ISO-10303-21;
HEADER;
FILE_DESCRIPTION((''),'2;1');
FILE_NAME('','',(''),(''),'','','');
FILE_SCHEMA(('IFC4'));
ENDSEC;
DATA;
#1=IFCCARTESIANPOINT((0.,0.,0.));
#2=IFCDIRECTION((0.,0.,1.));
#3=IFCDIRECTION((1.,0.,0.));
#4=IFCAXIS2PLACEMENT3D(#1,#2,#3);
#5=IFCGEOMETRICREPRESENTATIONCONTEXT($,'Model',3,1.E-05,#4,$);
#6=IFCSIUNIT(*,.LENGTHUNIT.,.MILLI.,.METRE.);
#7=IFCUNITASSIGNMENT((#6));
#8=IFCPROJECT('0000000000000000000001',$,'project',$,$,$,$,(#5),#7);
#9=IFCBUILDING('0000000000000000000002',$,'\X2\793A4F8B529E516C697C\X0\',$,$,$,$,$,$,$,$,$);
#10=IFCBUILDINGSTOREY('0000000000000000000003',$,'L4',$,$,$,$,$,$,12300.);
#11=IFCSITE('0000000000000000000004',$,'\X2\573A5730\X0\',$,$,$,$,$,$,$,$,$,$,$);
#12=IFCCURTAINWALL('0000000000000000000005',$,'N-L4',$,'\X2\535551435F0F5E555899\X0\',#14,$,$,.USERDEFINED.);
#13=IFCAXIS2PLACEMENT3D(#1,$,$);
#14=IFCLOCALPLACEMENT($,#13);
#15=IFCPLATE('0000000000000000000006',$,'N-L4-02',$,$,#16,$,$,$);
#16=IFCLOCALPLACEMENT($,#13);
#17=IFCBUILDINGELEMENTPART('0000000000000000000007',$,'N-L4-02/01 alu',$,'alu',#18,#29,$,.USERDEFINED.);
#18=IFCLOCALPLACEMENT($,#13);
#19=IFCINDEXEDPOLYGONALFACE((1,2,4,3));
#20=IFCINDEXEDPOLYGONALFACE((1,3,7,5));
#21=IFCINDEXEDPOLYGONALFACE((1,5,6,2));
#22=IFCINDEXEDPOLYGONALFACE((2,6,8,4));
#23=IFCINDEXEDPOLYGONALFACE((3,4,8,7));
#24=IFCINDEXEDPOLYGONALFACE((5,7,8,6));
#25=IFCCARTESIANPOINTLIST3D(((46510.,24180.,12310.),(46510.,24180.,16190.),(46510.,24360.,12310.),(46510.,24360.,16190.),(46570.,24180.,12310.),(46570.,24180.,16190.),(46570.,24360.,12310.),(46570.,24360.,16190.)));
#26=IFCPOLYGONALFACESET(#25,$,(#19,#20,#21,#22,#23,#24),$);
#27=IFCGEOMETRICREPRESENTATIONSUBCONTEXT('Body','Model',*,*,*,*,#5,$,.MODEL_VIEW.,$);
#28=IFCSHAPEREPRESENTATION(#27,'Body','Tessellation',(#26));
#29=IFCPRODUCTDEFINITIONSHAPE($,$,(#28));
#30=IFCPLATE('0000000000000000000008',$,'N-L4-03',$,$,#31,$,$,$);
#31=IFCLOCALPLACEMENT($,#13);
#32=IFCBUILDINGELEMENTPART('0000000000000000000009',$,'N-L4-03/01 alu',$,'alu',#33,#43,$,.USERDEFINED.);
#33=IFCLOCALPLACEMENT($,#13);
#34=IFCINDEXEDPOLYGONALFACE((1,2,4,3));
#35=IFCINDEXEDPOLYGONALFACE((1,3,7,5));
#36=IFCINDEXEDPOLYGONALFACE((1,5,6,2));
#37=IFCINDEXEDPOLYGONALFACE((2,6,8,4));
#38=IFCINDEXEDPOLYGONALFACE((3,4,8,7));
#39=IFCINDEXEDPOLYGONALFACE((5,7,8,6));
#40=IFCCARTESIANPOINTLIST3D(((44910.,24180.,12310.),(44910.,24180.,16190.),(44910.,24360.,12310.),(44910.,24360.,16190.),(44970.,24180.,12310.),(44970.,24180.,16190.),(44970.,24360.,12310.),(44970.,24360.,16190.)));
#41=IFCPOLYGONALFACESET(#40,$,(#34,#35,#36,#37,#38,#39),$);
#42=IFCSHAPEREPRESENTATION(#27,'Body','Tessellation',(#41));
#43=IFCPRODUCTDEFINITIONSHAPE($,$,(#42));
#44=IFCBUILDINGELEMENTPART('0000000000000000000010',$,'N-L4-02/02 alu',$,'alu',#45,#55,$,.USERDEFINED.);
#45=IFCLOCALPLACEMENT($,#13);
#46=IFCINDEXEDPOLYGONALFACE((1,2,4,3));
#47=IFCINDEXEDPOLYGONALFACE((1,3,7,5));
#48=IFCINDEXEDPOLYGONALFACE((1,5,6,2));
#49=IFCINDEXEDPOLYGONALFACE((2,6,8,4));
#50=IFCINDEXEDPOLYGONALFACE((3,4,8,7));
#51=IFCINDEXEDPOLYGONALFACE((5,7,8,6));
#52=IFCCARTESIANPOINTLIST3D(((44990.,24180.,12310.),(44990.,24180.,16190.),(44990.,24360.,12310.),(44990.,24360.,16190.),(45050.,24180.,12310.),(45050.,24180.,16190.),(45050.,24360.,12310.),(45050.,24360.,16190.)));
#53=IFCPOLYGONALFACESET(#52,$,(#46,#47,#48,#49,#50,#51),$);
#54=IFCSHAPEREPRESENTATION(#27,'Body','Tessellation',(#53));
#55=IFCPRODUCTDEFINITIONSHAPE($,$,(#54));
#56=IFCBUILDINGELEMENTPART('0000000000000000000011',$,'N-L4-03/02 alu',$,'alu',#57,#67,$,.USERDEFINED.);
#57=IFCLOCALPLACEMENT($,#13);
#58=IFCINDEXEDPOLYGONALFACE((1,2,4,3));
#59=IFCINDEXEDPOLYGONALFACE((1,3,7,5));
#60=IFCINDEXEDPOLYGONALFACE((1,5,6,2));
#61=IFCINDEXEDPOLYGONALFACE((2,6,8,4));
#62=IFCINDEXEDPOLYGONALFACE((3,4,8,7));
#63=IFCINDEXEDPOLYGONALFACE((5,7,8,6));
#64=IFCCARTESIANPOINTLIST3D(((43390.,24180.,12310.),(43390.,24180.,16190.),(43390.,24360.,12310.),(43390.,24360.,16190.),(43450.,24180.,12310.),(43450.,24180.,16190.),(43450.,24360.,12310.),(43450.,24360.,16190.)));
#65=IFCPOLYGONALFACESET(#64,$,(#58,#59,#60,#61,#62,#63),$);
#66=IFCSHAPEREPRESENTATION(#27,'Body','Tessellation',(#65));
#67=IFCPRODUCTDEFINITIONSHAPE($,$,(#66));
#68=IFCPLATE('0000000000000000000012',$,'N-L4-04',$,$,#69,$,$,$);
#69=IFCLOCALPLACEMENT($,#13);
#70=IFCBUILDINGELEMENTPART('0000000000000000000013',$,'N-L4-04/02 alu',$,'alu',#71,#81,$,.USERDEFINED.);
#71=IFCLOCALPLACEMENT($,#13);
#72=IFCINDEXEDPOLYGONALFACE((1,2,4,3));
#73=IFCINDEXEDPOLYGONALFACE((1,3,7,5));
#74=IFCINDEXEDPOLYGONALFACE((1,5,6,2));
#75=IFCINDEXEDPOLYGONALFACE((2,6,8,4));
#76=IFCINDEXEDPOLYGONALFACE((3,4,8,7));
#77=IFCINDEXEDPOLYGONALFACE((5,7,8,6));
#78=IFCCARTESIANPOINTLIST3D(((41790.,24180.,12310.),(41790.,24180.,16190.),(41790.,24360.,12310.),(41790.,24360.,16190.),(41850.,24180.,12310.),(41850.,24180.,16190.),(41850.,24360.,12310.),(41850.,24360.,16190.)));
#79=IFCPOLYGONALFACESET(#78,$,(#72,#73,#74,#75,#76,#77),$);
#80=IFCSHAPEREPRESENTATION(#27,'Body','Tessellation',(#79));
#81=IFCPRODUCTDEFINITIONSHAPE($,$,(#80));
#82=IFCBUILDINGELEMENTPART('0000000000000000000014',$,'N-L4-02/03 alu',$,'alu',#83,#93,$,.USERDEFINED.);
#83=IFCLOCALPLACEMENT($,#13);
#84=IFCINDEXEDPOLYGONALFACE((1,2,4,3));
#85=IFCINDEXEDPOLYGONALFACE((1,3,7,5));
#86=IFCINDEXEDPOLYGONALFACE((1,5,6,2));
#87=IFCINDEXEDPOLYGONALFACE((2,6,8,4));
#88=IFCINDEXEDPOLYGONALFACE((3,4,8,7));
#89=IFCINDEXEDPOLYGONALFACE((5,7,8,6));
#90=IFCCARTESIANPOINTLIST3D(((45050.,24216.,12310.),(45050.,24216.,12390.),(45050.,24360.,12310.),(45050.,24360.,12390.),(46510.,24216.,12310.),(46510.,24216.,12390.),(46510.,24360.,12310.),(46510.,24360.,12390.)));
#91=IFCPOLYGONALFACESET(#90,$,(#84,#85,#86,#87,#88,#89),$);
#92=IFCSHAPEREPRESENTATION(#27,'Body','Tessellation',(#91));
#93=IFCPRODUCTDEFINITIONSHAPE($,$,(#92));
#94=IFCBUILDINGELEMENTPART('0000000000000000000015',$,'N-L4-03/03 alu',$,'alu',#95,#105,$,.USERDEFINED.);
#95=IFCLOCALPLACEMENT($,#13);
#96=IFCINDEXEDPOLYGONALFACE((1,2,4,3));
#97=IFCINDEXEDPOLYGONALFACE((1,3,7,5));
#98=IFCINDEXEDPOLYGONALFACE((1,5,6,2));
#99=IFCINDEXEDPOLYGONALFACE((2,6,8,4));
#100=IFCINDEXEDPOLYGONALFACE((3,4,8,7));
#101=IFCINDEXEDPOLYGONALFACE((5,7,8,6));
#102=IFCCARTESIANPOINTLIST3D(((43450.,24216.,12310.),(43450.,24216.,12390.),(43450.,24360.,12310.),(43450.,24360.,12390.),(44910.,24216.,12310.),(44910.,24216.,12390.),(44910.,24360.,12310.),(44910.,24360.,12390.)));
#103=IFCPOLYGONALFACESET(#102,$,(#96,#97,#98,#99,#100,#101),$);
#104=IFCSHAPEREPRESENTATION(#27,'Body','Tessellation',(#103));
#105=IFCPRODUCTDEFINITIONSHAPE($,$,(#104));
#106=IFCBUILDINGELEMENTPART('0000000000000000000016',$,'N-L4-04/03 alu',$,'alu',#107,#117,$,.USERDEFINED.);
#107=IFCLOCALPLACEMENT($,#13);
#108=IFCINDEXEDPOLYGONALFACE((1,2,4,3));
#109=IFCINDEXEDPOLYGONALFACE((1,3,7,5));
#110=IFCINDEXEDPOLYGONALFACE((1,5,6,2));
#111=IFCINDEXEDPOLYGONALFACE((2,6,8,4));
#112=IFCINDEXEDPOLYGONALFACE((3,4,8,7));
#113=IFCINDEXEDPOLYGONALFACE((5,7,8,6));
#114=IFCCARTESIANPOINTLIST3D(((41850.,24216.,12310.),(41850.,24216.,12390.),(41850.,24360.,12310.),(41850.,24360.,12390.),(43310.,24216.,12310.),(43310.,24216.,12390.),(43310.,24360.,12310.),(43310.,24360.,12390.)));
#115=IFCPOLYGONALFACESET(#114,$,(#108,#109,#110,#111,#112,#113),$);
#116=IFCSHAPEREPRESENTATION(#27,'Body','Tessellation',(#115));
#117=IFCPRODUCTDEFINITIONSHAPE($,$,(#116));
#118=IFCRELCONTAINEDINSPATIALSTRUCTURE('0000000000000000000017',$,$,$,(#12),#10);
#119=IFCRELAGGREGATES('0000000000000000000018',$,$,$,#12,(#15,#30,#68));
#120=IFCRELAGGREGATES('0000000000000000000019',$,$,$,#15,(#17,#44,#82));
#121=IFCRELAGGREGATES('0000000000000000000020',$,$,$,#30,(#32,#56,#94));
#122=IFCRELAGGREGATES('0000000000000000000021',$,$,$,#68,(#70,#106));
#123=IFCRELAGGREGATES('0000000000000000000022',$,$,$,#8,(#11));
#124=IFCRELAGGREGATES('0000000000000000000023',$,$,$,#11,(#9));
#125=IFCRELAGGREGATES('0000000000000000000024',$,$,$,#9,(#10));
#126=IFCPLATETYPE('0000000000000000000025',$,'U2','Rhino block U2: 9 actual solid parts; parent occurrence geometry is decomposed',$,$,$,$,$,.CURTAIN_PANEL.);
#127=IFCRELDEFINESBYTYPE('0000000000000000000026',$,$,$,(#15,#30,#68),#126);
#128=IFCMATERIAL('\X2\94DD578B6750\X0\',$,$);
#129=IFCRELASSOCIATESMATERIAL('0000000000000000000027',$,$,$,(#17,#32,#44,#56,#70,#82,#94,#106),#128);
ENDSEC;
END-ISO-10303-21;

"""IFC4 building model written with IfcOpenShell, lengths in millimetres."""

from ifc_helpers import new_model, si_unit, frame, frame_2d, origin, origin_with_axes, place, context, subcontext, project, spatial, rectangle, extrude, source, transform, mapped, material, type_object, element, aggregate, save


model = new_model("IFC4")

# Units and contexts
model_context = context("Model", 3, precision=1e-05, world=origin_with_axes())
body_context = subcontext(model_context, "Body", "Model", "MODEL_VIEW")
ifc_project = project(units=[si_unit("LENGTHUNIT", "METRE", prefix="MILLI")], contexts=[model_context])

# Site, building, storey
site = spatial("IfcSite", under=ifc_project, Name="场地")
building = spatial("IfcBuilding", under=site, Name="示例办公楼")
storey = spatial("IfcBuildingStorey", under=building, Name="L4", Elevation=12300.0)

# Curtain wall, plates, building element parts
curtain_wall = element("IfcCurtainWall", 1, inside=storey, Name="N-L4", ObjectType="单元式幕墙", PredefinedType="USERDEFINED")
plate_type = type_object("IfcPlateType", Name="U2", Description="Rhino block U2: 9 actual solid parts; parent occurrence geometry is decomposed", PredefinedType="CURTAIN_PANEL")
plate_1_placement = place(None, frame((46570.0, 24360.0, 12310.0), z_axis=(0.0, 0.0, 1.0), x_axis=(-1.0, 0.0, 0.0)))
plate_1 = element("IfcPlate", 2, at=plate_1_placement, type_object=plate_type, Name="N-L4-02")
ifc_material_1 = material(Name="铝型材")
shared_shape_1 = source(origin(), body_context, "Body", "SweptSolid", [
    extrude(rectangle(XDim=60.0, YDim=180.0, at=frame_2d((30.0, 90.0))), origin(), (0.0, 0.0, 1.0), 3880.0),
])
building_element_part_1_placement = place(plate_1_placement, origin())
building_element_part_1 = element("IfcBuildingElementPart", 3, at=building_element_part_1_placement, material=ifc_material_1, Name="N-L4-02/01 alu", ObjectType="alu", PredefinedType="USERDEFINED", context=body_context, shape_type="MappedRepresentation", body=[
    mapped(shared_shape_1, transform((0.0, 0.0, 0.0))),
])
plate_2_placement = place(None, frame((44970.0, 24360.0, 12310.0), z_axis=(0.0, 0.0, 1.0), x_axis=(-1.0, 0.0, 0.0)))
plate_2 = element("IfcPlate", 4, at=plate_2_placement, type_object=plate_type, Name="N-L4-03")
building_element_part_2_placement = place(plate_2_placement, origin())
building_element_part_2 = element("IfcBuildingElementPart", 5, at=building_element_part_2_placement, material=ifc_material_1, Name="N-L4-03/01 alu", ObjectType="alu", PredefinedType="USERDEFINED", context=body_context, shape_type="MappedRepresentation", body=[
    mapped(shared_shape_1, transform((0.0, 0.0, 0.0))),
])
shared_shape_2 = source(origin(), body_context, "Body", "SweptSolid", [
    extrude(rectangle(XDim=60.0, YDim=180.0, at=frame_2d((1550.0, 90.0))), origin(), (0.0, 0.0, 1.0), 3880.0),
])
building_element_part_3_placement = place(plate_1_placement, origin())
building_element_part_3 = element("IfcBuildingElementPart", 6, at=building_element_part_3_placement, material=ifc_material_1, Name="N-L4-02/02 alu", ObjectType="alu", PredefinedType="USERDEFINED", context=body_context, shape_type="MappedRepresentation", body=[
    mapped(shared_shape_2, transform((0.0, 0.0, 0.0))),
])
building_element_part_4_placement = place(plate_2_placement, origin())
building_element_part_4 = element("IfcBuildingElementPart", 7, at=building_element_part_4_placement, material=ifc_material_1, Name="N-L4-03/02 alu", ObjectType="alu", PredefinedType="USERDEFINED", context=body_context, shape_type="MappedRepresentation", body=[
    mapped(shared_shape_2, transform((0.0, 0.0, 0.0))),
])
plate_3_placement = place(None, frame((43370.0, 24360.0, 12310.0), z_axis=(0.0, 0.0, 1.0), x_axis=(-1.0, 0.0, 0.0)))
plate_3 = element("IfcPlate", 8, at=plate_3_placement, type_object=plate_type, Name="N-L4-04")
aggregate(curtain_wall, [plate_1, plate_2, plate_3])
building_element_part_5_placement = place(plate_3_placement, origin())
building_element_part_5 = element("IfcBuildingElementPart", 9, at=building_element_part_5_placement, material=ifc_material_1, Name="N-L4-04/02 alu", ObjectType="alu", PredefinedType="USERDEFINED", context=body_context, shape_type="MappedRepresentation", body=[
    mapped(shared_shape_2, transform((0.0, 0.0, 0.0))),
])
shared_shape_3 = source(origin(), body_context, "Body", "SweptSolid", [
    extrude(rectangle(XDim=1460.0, YDim=144.0, at=frame_2d((790.0, 72.0))), origin(), (0.0, 0.0, 1.0), 80.0),
])
building_element_part_6_placement = place(plate_1_placement, origin())
building_element_part_6 = element("IfcBuildingElementPart", 10, at=building_element_part_6_placement, material=ifc_material_1, Name="N-L4-02/03 alu", ObjectType="alu", PredefinedType="USERDEFINED", context=body_context, shape_type="MappedRepresentation", body=[
    mapped(shared_shape_3, transform((0.0, 0.0, 0.0))),
])
building_element_part_7_placement = place(plate_2_placement, origin())
building_element_part_7 = element("IfcBuildingElementPart", 11, at=building_element_part_7_placement, material=ifc_material_1, Name="N-L4-03/03 alu", ObjectType="alu", PredefinedType="USERDEFINED", context=body_context, shape_type="MappedRepresentation", body=[
    mapped(shared_shape_3, transform((0.0, 0.0, 0.0))),
])
building_element_part_8_placement = place(plate_3_placement, origin())
building_element_part_8 = element("IfcBuildingElementPart", 12, at=building_element_part_8_placement, material=ifc_material_1, Name="N-L4-04/03 alu", ObjectType="alu", PredefinedType="USERDEFINED", context=body_context, shape_type="MappedRepresentation", body=[
    mapped(shared_shape_3, transform((0.0, 0.0, 0.0))),
])
aggregate(plate_1, [building_element_part_1, building_element_part_3, building_element_part_6])
aggregate(plate_2, [building_element_part_2, building_element_part_4, building_element_part_7])
aggregate(plate_3, [building_element_part_5, building_element_part_8])

save(model, "model.ifc")
